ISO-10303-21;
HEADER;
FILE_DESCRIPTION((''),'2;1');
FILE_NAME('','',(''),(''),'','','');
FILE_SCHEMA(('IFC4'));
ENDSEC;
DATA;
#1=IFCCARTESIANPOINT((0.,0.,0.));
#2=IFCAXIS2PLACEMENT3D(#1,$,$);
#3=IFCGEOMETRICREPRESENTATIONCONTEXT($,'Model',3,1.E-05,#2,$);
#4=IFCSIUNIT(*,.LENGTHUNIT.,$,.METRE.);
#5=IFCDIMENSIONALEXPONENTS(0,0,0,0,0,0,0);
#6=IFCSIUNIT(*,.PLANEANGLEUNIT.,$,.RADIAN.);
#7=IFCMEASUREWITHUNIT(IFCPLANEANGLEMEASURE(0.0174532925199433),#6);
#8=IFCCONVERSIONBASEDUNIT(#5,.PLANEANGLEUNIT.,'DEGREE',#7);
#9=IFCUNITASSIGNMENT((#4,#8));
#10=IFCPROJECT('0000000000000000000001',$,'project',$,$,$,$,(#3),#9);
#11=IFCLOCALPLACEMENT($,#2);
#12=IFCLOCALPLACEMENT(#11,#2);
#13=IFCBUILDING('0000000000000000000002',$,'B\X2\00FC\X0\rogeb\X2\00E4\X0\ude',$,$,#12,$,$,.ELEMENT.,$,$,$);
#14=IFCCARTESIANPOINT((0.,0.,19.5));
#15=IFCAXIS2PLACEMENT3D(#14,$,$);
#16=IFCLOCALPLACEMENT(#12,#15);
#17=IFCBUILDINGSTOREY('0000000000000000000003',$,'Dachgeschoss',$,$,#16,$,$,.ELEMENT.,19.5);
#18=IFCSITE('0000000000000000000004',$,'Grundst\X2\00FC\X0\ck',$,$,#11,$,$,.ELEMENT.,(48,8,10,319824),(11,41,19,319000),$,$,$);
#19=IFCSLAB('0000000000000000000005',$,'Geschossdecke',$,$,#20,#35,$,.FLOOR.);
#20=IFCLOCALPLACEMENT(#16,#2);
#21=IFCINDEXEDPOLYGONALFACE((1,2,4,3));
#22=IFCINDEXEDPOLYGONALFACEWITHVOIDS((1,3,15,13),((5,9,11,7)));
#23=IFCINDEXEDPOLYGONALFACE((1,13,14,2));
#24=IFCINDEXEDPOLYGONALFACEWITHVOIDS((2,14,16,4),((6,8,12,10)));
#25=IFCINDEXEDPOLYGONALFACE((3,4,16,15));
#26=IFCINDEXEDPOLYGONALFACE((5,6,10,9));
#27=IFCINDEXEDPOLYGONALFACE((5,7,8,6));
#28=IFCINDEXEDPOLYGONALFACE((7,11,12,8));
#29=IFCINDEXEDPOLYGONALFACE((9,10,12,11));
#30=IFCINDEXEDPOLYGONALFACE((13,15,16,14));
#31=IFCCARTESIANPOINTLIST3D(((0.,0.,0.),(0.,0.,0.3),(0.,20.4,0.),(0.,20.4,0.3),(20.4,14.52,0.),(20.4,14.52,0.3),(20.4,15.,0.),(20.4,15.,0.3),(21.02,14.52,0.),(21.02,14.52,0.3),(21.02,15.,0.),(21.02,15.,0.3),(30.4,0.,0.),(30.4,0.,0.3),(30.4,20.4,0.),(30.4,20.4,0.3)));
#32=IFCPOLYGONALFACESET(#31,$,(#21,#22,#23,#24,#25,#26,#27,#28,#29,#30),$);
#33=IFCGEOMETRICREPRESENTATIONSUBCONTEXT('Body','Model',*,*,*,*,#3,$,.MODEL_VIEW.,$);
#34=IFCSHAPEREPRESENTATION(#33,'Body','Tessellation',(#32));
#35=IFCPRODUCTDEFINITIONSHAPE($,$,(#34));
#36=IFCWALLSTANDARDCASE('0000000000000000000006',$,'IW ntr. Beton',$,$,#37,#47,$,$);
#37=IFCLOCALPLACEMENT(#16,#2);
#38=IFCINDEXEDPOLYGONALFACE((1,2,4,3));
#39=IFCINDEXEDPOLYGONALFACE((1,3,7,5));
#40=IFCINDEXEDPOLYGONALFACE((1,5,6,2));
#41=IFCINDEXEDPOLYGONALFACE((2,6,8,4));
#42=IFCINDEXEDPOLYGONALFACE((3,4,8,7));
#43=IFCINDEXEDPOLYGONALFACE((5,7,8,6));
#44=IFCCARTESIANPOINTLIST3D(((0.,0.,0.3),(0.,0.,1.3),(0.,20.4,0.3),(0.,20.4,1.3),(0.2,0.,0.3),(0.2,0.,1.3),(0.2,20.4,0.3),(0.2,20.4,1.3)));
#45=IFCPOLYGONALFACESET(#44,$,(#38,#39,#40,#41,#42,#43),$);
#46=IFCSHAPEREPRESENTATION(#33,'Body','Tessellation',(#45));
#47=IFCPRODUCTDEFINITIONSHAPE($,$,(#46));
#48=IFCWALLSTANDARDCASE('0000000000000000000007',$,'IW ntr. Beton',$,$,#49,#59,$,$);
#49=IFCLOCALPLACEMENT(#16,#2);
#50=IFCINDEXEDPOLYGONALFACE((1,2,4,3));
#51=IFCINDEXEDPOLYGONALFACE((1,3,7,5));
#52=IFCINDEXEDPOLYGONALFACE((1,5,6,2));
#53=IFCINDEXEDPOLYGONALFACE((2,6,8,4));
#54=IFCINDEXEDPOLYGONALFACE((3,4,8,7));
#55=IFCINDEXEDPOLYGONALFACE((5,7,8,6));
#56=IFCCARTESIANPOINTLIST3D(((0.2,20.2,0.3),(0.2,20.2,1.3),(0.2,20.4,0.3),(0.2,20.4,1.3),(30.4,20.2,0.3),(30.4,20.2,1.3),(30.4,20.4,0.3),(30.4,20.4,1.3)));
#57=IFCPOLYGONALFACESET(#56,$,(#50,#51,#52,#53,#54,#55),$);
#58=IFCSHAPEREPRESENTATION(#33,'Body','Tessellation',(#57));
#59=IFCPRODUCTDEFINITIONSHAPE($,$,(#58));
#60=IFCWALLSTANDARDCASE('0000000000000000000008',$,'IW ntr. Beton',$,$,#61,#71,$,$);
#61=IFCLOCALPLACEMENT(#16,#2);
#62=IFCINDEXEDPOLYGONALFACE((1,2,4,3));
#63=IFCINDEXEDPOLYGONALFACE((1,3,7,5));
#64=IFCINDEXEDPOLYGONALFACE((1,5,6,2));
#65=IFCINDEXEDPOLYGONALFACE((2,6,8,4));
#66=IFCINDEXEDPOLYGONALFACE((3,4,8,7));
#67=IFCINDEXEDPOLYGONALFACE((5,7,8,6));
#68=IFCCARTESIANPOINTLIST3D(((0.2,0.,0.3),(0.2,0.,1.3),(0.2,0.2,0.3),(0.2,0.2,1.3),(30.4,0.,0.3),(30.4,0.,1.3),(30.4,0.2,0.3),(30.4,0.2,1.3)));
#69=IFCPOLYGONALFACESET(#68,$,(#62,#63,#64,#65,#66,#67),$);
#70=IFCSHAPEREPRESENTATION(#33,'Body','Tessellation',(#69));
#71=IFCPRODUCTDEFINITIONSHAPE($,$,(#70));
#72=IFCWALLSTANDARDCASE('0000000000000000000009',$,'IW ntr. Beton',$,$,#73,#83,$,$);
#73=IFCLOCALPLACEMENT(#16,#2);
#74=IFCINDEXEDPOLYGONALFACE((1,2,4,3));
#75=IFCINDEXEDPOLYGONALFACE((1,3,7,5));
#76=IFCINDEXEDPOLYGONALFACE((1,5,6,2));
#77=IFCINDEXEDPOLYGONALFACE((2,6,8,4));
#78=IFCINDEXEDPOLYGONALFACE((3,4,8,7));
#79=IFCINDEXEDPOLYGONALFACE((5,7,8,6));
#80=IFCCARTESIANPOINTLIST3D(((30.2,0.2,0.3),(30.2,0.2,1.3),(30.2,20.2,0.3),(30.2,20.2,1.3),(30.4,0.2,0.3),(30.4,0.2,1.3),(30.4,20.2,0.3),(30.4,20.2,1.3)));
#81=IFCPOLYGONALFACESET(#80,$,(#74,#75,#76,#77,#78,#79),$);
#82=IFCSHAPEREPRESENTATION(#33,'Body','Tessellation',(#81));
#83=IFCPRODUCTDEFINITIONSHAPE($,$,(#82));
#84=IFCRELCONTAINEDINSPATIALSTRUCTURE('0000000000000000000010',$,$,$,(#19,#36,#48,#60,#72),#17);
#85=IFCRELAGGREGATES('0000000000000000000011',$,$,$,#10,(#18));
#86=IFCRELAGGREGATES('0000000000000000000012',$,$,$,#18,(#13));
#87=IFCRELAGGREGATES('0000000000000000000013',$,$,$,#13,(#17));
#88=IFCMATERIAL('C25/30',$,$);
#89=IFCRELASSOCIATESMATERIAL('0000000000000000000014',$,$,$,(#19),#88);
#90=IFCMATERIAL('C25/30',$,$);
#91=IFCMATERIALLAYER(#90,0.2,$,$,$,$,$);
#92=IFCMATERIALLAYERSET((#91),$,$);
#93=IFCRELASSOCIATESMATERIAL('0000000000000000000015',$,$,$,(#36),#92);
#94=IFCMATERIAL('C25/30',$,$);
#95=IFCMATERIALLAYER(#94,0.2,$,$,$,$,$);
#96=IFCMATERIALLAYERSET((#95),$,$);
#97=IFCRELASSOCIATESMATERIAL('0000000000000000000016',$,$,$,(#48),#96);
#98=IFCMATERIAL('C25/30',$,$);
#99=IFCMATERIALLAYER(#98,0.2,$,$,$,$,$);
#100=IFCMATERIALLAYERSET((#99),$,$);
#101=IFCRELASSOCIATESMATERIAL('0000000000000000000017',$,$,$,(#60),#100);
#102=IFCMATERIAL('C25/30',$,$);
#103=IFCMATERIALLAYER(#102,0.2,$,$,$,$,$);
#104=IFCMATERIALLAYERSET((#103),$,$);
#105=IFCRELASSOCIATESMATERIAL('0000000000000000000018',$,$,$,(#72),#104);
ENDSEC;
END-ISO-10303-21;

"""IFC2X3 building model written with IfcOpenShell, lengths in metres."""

from ifc_helpers import new_model, entity, si_unit, converted_unit, frame, frame_2d, origin, origin_with_axes, place, context, subcontext, project, spatial, rectangle, extrude, material, layer, layer_set, layer_usage, element, save


model = new_model("IFC2X3")

# Units and contexts
model_context = context("Model", 3, precision=1e-05, world=origin())
body_context = subcontext(model_context, "Body", "Model", "MODEL_VIEW")
ifc_project = project(units=[si_unit("LENGTHUNIT", "METRE"), converted_unit("PLANEANGLEUNIT", "DEGREE", entity("IfcPlaneAngleMeasure", 0.0174532925199433), si_unit("PLANEANGLEUNIT", "RADIAN"), dimensions=[0, 0, 0, 0, 0, 0, 0])], contexts=[model_context])

# Site, building, storey
site_placement = place(None, origin())
site = spatial("IfcSite", under=ifc_project, at=site_placement, Name="Grundstück", CompositionType="ELEMENT", RefLatitude=(48, 8, 10, 319824), RefLongitude=(11, 41, 19, 319000))
building_placement = place(site_placement, origin())
building = spatial("IfcBuilding", under=site, at=building_placement, Name="Bürogebäude", CompositionType="ELEMENT")
storey_placement = place(building_placement, frame((0.0, 0.0, 19.5)))
storey = spatial("IfcBuildingStorey", under=building, at=storey_placement, Name="Dachgeschoss", CompositionType="ELEMENT", Elevation=19.5)

# Slab, opening
ifc_material_1 = material(Name="C25/30")
slab_placement = place(storey_placement, frame((0.0, 0.0, 0.0)))
slab = element("IfcSlab", 1, at=slab_placement, inside=storey, material=ifc_material_1, Name="Geschossdecke", PredefinedType="FLOOR", context=body_context, shape_type="SweptSolid", body=[
    extrude(rectangle(XDim=30.4, YDim=20.4, at=frame_2d((15.2, 10.2), x_axis=(1.0, 0.0))), origin_with_axes(), (0.0, 0.0, 1.0), 0.3),
])
opening_placement = place(slab_placement, frame((20.4, 14.52, 0.0)))
element("IfcOpeningElement", 2, at=opening_placement, cuts=slab, ObjectType="Opening", context=body_context, shape_type="SweptSolid", body=[
    extrude(rectangle(XDim=0.48, YDim=0.62, at=frame_2d((0.0, 0.0), x_axis=(0.0, -1.0))), frame((0.31, 0.24, 0.0), z_axis=(0.0, 0.0, 1.0), x_axis=(1.0, 0.0, 0.0)), (0.0, 0.0, 1.0), 0.3),
])

# Walls
ifc_material_2 = material(Name="C25/30")
ifc_layer_1 = layer(ifc_material_2, 0.2)
ifc_layer_set_1 = layer_set([ifc_layer_1])
ifc_layer_usage_1 = layer_usage(ifc_layer_set_1, "AXIS2", "POSITIVE", -0.2)
wall_1_placement = place(storey_placement, frame((0.2, 0.0, 0.3), z_axis=(0.0, 0.0, 1.0), x_axis=(0.0, 1.0, 0.0)))
element("IfcWallStandardCase", 3, at=wall_1_placement, inside=storey, material=ifc_layer_usage_1, Name="IW ntr. Beton", context=body_context, shape_type="SweptSolid", body=[
    extrude(rectangle(XDim=20.4, YDim=0.2, at=frame_2d((10.2, 0.1), x_axis=(1.0, 0.0))), origin_with_axes(), (0.0, 0.0, 1.0), 1.0),
])
ifc_material_3 = material(Name="C25/30")
ifc_layer_2 = layer(ifc_material_3, 0.2)
ifc_layer_set_2 = layer_set([ifc_layer_2])
ifc_layer_usage_2 = layer_usage(ifc_layer_set_2, "AXIS2", "POSITIVE", -0.2)
wall_2_placement = place(storey_placement, frame((0.2, 20.2, 0.3)))
element("IfcWallStandardCase", 4, at=wall_2_placement, inside=storey, material=ifc_layer_usage_2, Name="IW ntr. Beton", context=body_context, shape_type="SweptSolid", body=[
    extrude(rectangle(XDim=30.2, YDim=0.2, at=frame_2d((15.1, 0.1), x_axis=(1.0, 0.0))), origin_with_axes(), (0.0, 0.0, 1.0), 1.0),
])
ifc_material_4 = material(Name="C25/30")
ifc_layer_3 = layer(ifc_material_4, 0.2)
ifc_layer_set_3 = layer_set([ifc_layer_3])
ifc_layer_usage_3 = layer_usage(ifc_layer_set_3, "AXIS2", "POSITIVE", -0.2)
wall_3_placement = place(storey_placement, frame((30.4, 0.2, 0.3), z_axis=(0.0, 0.0, 1.0), x_axis=(-1.0, 0.0, 0.0)))
element("IfcWallStandardCase", 5, at=wall_3_placement, inside=storey, material=ifc_layer_usage_3, Name="IW ntr. Beton", context=body_context, shape_type="SweptSolid", body=[
    extrude(rectangle(XDim=30.2, YDim=0.2, at=frame_2d((15.1, 0.1), x_axis=(1.0, 0.0))), origin_with_axes(), (0.0, 0.0, 1.0), 1.0),
])
ifc_material_5 = material(Name="C25/30")
ifc_layer_4 = layer(ifc_material_5, 0.2)
ifc_layer_set_4 = layer_set([ifc_layer_4])
ifc_layer_usage_4 = layer_usage(ifc_layer_set_4, "AXIS2", "POSITIVE", -0.2)
wall_4_placement = place(storey_placement, frame((30.2, 20.2, 0.3), z_axis=(0.0, 0.0, 1.0), x_axis=(0.0, -1.0, 0.0)))
element("IfcWallStandardCase", 6, at=wall_4_placement, inside=storey, material=ifc_layer_usage_4, Name="IW ntr. Beton", context=body_context, shape_type="SweptSolid", body=[
    extrude(rectangle(XDim=20.0, YDim=0.2, at=frame_2d((10.0, 0.1), x_axis=(1.0, 0.0))), origin_with_axes(), (0.0, 0.0, 1.0), 1.0),
])

save(model, "model.ifc")
